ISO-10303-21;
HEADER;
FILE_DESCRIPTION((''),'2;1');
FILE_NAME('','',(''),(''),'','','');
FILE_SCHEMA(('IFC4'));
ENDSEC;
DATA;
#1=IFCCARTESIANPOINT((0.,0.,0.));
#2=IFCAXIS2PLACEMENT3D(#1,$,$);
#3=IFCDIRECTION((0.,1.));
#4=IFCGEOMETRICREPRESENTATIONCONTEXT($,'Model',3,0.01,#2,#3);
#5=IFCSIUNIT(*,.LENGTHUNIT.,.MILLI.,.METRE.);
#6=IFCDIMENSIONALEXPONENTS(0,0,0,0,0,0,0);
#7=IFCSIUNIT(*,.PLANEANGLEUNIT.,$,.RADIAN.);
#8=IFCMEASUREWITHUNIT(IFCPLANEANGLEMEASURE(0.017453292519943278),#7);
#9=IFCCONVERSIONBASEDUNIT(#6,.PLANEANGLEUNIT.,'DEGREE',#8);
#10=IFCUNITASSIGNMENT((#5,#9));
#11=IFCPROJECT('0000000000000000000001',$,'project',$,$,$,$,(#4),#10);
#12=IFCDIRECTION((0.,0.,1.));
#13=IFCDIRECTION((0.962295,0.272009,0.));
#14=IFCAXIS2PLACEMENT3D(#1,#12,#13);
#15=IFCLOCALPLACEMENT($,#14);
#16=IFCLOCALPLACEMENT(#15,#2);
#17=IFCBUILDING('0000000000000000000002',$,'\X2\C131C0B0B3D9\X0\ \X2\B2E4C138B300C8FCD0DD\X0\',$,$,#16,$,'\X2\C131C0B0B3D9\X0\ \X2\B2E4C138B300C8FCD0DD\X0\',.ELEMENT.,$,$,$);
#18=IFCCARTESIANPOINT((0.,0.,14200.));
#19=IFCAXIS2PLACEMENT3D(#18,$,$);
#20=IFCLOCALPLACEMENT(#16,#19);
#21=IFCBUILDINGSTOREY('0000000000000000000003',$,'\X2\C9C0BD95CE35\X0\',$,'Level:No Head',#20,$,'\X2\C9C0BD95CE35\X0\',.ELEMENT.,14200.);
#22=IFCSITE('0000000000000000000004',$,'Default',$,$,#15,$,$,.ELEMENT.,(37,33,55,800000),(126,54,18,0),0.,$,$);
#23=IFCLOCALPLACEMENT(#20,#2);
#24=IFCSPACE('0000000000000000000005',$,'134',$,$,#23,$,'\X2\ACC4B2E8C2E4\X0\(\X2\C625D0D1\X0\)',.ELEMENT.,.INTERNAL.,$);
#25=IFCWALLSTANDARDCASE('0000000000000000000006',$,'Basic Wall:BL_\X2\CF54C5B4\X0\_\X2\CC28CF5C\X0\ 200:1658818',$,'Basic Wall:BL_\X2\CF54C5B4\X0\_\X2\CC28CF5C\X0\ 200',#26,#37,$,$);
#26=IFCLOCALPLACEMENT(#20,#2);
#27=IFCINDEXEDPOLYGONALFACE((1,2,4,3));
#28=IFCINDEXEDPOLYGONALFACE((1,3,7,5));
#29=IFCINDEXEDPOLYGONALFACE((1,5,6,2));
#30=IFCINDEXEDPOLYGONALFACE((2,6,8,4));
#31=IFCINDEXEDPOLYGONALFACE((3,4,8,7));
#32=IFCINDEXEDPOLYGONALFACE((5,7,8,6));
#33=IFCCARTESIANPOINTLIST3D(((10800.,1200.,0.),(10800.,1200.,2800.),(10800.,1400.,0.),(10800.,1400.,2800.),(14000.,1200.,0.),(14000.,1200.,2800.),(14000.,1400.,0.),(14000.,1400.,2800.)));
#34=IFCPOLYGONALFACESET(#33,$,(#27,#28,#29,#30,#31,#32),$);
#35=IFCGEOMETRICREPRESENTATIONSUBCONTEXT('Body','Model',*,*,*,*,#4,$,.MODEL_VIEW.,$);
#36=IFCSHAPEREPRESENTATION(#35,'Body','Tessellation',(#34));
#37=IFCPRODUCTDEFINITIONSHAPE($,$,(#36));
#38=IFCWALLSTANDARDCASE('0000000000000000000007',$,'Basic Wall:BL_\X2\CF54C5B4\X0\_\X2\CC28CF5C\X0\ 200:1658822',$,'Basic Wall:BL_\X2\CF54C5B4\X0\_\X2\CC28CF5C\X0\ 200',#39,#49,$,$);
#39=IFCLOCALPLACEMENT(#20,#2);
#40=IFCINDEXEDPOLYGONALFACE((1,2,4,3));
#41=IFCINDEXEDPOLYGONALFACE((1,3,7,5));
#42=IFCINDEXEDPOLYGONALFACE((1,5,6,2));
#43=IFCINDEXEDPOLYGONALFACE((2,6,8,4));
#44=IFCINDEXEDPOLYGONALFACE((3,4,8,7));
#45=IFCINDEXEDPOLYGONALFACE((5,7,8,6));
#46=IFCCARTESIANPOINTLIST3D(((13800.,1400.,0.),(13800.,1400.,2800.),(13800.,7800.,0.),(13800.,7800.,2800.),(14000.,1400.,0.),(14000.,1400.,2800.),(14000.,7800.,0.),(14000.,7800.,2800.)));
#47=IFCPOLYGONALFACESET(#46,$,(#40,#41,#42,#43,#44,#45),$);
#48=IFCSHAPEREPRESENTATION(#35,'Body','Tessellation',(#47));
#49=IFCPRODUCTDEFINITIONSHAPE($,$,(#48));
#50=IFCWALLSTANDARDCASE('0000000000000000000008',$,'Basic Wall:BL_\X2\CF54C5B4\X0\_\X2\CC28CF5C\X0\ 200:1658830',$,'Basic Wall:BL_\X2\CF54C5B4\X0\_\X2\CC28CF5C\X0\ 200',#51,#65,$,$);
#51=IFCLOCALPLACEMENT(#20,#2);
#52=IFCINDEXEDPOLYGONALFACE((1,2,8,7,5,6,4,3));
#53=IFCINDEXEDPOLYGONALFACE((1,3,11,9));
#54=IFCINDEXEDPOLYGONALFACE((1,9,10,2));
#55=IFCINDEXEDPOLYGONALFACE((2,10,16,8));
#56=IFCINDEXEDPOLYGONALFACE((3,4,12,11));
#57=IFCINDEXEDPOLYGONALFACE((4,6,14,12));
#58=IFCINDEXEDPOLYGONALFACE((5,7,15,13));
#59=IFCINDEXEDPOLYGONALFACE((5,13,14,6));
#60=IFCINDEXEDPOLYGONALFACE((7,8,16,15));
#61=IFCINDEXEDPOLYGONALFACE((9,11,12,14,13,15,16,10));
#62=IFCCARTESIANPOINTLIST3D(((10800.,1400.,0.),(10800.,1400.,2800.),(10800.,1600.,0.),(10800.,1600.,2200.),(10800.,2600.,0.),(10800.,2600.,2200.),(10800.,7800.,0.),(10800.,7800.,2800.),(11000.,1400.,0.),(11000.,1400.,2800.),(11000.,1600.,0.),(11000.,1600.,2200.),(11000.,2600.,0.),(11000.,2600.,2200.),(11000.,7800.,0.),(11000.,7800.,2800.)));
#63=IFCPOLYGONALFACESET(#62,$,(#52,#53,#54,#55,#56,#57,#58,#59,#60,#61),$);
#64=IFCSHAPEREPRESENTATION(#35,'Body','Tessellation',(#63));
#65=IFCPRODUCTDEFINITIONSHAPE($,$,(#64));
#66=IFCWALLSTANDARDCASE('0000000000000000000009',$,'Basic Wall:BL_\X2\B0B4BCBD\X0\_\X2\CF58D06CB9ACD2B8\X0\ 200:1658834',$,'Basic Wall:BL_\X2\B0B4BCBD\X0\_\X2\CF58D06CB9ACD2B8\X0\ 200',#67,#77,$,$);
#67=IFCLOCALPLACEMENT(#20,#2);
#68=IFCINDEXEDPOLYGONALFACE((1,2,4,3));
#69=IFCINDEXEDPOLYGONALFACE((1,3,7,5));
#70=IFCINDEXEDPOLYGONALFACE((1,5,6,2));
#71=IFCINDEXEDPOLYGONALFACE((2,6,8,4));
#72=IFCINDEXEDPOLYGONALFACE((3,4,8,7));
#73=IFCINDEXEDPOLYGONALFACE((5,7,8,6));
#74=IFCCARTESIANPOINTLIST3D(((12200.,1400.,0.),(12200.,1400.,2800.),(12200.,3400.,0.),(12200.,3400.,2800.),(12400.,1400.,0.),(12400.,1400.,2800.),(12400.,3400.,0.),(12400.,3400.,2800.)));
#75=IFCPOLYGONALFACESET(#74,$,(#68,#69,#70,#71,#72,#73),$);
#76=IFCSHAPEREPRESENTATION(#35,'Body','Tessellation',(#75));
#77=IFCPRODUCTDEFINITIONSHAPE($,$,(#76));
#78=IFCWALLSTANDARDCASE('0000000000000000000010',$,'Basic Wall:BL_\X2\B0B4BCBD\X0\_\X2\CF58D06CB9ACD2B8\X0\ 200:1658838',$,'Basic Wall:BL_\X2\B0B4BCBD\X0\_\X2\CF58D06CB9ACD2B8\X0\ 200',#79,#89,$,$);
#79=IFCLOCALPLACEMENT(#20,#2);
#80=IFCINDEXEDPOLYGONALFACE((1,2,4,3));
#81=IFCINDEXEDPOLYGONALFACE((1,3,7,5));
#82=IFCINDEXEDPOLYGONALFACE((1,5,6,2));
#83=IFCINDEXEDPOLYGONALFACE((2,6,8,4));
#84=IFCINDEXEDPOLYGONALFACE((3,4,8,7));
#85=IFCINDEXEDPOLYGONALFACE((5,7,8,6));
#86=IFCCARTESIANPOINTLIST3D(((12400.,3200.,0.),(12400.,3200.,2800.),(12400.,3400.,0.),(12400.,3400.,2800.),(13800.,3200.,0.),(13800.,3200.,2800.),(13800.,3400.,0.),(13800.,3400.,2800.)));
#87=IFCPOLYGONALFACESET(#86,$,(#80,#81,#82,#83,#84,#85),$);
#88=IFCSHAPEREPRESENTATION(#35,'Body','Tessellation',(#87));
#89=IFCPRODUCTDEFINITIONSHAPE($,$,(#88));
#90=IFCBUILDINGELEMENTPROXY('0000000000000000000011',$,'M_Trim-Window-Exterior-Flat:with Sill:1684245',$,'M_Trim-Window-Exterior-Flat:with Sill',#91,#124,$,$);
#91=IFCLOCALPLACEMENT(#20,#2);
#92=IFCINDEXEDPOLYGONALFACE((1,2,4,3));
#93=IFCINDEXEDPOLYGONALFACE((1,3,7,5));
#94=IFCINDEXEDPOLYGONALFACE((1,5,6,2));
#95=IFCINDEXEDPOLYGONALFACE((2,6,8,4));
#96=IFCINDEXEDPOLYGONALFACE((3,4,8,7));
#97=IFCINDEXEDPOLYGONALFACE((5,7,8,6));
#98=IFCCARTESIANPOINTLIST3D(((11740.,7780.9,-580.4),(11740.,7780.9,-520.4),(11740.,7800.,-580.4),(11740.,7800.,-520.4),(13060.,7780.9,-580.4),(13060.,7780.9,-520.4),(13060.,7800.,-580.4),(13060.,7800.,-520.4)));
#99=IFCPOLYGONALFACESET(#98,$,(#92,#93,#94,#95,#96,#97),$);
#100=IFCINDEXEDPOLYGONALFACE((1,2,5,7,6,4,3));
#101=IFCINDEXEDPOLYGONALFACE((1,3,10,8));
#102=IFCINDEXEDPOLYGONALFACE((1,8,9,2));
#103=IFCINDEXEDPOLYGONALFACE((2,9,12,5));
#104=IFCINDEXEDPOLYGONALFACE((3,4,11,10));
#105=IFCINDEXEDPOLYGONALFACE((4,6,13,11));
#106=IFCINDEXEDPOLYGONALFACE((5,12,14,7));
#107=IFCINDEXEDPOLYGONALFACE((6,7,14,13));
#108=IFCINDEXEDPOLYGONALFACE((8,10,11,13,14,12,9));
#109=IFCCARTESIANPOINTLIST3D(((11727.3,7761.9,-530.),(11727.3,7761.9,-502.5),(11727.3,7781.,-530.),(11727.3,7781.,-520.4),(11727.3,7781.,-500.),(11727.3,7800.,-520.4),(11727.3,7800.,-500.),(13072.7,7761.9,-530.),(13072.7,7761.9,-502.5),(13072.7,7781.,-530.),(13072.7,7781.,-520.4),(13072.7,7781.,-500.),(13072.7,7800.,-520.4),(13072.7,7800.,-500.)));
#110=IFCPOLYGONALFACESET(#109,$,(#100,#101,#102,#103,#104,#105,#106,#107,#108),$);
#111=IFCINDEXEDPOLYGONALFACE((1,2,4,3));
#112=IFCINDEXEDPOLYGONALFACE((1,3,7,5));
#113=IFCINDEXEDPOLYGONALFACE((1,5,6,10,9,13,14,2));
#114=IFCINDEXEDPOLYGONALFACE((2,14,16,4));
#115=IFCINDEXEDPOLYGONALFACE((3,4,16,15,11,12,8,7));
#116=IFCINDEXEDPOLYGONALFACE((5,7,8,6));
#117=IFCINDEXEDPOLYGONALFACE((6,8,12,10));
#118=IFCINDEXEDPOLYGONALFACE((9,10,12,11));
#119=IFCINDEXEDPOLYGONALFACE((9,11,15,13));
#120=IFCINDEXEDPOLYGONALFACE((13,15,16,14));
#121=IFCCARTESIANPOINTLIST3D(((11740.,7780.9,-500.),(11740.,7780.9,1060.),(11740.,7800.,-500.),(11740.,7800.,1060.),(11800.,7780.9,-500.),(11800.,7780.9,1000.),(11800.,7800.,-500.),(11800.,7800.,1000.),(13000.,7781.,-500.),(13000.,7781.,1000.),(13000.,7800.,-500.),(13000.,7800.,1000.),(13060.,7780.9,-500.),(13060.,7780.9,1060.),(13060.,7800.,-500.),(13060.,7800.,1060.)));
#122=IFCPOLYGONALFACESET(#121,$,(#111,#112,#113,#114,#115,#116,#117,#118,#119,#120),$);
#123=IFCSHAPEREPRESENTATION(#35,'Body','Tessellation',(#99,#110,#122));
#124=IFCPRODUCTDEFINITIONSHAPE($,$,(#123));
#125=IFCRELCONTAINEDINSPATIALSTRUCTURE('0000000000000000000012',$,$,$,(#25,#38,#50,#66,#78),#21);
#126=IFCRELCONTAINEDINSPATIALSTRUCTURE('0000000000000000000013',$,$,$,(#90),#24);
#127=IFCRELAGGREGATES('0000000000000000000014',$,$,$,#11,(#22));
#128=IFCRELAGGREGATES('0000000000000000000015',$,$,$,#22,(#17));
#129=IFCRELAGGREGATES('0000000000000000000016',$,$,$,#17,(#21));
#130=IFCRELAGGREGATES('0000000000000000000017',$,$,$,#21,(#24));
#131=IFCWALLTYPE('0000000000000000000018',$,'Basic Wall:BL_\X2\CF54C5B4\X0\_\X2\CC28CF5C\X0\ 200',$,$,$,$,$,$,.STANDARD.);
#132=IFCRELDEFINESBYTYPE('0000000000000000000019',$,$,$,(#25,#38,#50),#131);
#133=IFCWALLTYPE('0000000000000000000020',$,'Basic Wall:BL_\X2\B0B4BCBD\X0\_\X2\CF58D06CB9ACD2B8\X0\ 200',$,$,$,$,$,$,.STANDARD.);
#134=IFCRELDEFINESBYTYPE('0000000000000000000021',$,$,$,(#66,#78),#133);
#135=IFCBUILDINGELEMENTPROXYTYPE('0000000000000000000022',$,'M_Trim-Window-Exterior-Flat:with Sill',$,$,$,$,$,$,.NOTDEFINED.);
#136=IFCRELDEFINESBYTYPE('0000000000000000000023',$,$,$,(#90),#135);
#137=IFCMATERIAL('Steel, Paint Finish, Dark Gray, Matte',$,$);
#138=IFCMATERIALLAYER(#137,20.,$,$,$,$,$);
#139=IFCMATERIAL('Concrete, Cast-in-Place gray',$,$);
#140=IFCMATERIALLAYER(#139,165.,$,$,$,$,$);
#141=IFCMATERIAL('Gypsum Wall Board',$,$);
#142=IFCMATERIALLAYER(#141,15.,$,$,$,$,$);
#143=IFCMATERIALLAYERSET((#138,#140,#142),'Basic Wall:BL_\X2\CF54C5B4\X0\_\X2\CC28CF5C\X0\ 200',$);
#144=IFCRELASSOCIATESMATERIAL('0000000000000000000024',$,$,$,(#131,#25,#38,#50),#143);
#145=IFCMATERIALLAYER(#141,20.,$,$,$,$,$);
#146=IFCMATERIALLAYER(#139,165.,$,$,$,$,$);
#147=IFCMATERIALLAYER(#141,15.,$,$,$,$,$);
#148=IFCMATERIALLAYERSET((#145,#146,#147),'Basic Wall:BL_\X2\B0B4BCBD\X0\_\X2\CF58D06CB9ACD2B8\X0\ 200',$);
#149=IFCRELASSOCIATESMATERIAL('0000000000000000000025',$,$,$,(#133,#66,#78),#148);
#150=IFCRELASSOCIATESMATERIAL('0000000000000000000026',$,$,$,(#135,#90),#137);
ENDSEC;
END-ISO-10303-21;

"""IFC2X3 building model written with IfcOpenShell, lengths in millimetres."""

from ifc_helpers import new_model, entity, si_unit, converted_unit, direction, frame, frame_2d, origin, place, context, subcontext, project, spatial, polyline, rectangle, outline, extrude, source, transform, mapped, material, layer, layer_set, layer_usage, type_object, type_shapes, element, save


model = new_model("IFC2X3")

# Units and contexts
model_context = context("Model", 3, precision=0.01, world=origin(), true_north=direction((0.0, 1.0)))
body_context = subcontext(model_context, "Body", "Model", "MODEL_VIEW")
ifc_project = project(units=[si_unit("LENGTHUNIT", "METRE", prefix="MILLI"), converted_unit("PLANEANGLEUNIT", "DEGREE", entity("IfcPlaneAngleMeasure", 0.017453292519943278), si_unit("PLANEANGLEUNIT", "RADIAN"), dimensions=[0, 0, 0, 0, 0, 0, 0])], contexts=[model_context])

# Site, building, storey
site_placement = place(None, frame((0.0, 0.0, 0.0), z_axis=(0.0, 0.0, 1.0), x_axis=(0.962295, 0.272009, 0.0)))
site = spatial("IfcSite", under=ifc_project, at=site_placement, Name="Default", CompositionType="ELEMENT", RefLatitude=(37, 33, 55, 800000), RefLongitude=(126, 54, 18, 0), RefElevation=0.0)
building_placement = place(site_placement, origin())
building = spatial("IfcBuilding", under=site, at=building_placement, Name="성산동 다세대주택", LongName="성산동 다세대주택", CompositionType="ELEMENT")
storey_placement = place(building_placement, frame((0.0, 0.0, 14200.0)))
storey = spatial("IfcBuildingStorey", under=building, at=storey_placement, Name="지붕층", ObjectType="Level:No Head", LongName="지붕층", CompositionType="ELEMENT", Elevation=14200.0)

# Shared definitions
ifc_material_1 = material(Name="Concrete, Cast-in-Place gray")

# Walls
ifc_material_2 = material(Name="Steel, Paint Finish, Dark Gray, Matte")
ifc_layer_1 = layer(ifc_material_2, 20.0)
ifc_layer_2 = layer(ifc_material_1, 165.0)
ifc_material_3 = material(Name="Gypsum Wall Board")
ifc_layer_3 = layer(ifc_material_3, 15.0)
ifc_layer_set_1 = layer_set([ifc_layer_1, ifc_layer_2, ifc_layer_3], Name="Basic Wall:BL_코어_차콜 200")
ifc_layer_usage_1 = layer_usage(ifc_layer_set_1, "AXIS2", "POSITIVE", -100.0)
wall_type_1 = type_object("IfcWallType", Name="Basic Wall:BL_코어_차콜 200", PredefinedType="STANDARD", material=ifc_layer_set_1)
wall_1_placement = place(storey_placement, frame((10800.0, 1300.0, 0.0)))
element("IfcWallStandardCase", 1, at=wall_1_placement, inside=storey, type_object=wall_type_1, material=ifc_layer_usage_1, Name="Basic Wall:BL_코어_차콜 200:1658818", ObjectType="Basic Wall:BL_코어_차콜 200", context=body_context, shape_type="SweptSolid", body=[
    extrude(rectangle(XDim=3200.0, YDim=200.0, at=frame_2d((1600.0, 0.0), x_axis=(-1.0, 0.0))), origin(), (0.0, 0.0, 1.0), 2800.0),
])
ifc_layer_usage_2 = layer_usage(ifc_layer_set_1, "AXIS2", "POSITIVE", -100.0)
wall_2_placement = place(storey_placement, frame((13900.0, 1400.0, 0.0), z_axis=(0.0, 0.0, 1.0), x_axis=(0.0, 1.0, 0.0)))
element("IfcWallStandardCase", 2, at=wall_2_placement, inside=storey, type_object=wall_type_1, material=ifc_layer_usage_2, Name="Basic Wall:BL_코어_차콜 200:1658822", ObjectType="Basic Wall:BL_코어_차콜 200", context=body_context, shape_type="SweptSolid", body=[
    extrude(rectangle(XDim=6400.0, YDim=200.0, at=frame_2d((3200.0, 0.0), x_axis=(-1.0, 0.0))), origin(), (0.0, 0.0, 1.0), 2800.0),
])

# Wall, opening
ifc_layer_usage_3 = layer_usage(ifc_layer_set_1, "AXIS2", "POSITIVE", -100.0)
wall_3_placement = place(storey_placement, frame((10900.0, 7800.0, 0.0), z_axis=(0.0, 0.0, 1.0), x_axis=(0.0, -1.0, 0.0)))
wall_3 = element("IfcWallStandardCase", 3, at=wall_3_placement, inside=storey, type_object=wall_type_1, material=ifc_layer_usage_3, Name="Basic Wall:BL_코어_차콜 200:1658830", ObjectType="Basic Wall:BL_코어_차콜 200", context=body_context, shape_type="SweptSolid", body=[
    extrude(rectangle(XDim=6400.0, YDim=200.0, at=frame_2d((3200.0, 0.0), x_axis=(1.0, 0.0))), origin(), (0.0, 0.0, 1.0), 2800.0),
])
opening_placement = place(wall_3_placement, frame((5200.0, -100.0, 0.0)))
element("IfcOpeningElement", 4, at=opening_placement, cuts=wall_3, ObjectType="Opening", context=body_context, shape_type="SweptSolid", body=[
    extrude(rectangle(XDim=2200.0, YDim=1000.0, at=frame_2d((1100.0, 500.0), x_axis=(1.0, 0.0))), frame((0.0, 0.0, 0.0), z_axis=(0.0, 1.0, 0.0), x_axis=(0.0, 0.0, 1.0)), (0.0, 0.0, 1.0), 200.0),
])

# Walls
ifc_layer_4 = layer(ifc_material_3, 20.0)
ifc_layer_5 = layer(ifc_material_1, 165.0)
ifc_layer_6 = layer(ifc_material_3, 15.0)
ifc_layer_set_2 = layer_set([ifc_layer_4, ifc_layer_5, ifc_layer_6], Name="Basic Wall:BL_내벽_콘크리트 200")
ifc_layer_usage_4 = layer_usage(ifc_layer_set_2, "AXIS2", "NEGATIVE", 100.0)
wall_type_2 = type_object("IfcWallType", Name="Basic Wall:BL_내벽_콘크리트 200", PredefinedType="STANDARD", material=ifc_layer_set_2)
wall_4_placement = place(storey_placement, frame((12300.0, 1400.0, 0.0), z_axis=(0.0, 0.0, 1.0), x_axis=(0.0, 1.0, 0.0)))
element("IfcWallStandardCase", 5, at=wall_4_placement, inside=storey, type_object=wall_type_2, material=ifc_layer_usage_4, Name="Basic Wall:BL_내벽_콘크리트 200:1658834", ObjectType="Basic Wall:BL_내벽_콘크리트 200", context=body_context, shape_type="SweptSolid", body=[
    extrude(rectangle(XDim=2000.0, YDim=200.0, at=frame_2d((1000.0, 0.0), x_axis=(-1.0, 0.0))), origin(), (0.0, 0.0, 1.0), 2800.0),
])
ifc_layer_usage_5 = layer_usage(ifc_layer_set_2, "AXIS2", "NEGATIVE", 100.0)
wall_5_placement = place(storey_placement, frame((12400.0, 3300.0, 0.0)))
element("IfcWallStandardCase", 6, at=wall_5_placement, inside=storey, type_object=wall_type_2, material=ifc_layer_usage_5, Name="Basic Wall:BL_내벽_콘크리트 200:1658838", ObjectType="Basic Wall:BL_내벽_콘크리트 200", context=body_context, shape_type="SweptSolid", body=[
    extrude(rectangle(XDim=1400.0, YDim=200.0, at=frame_2d((700.0, 0.0), x_axis=(-1.0, 0.0))), origin(), (0.0, 0.0, 1.0), 2800.0),
])

# Shared definitions
space_placement = place(storey_placement, origin())
space = spatial("IfcSpace", under=storey, at=space_placement, Name="134", LongName="계단실(옥탑)", CompositionType="ELEMENT", InteriorOrExteriorSpace="INTERNAL")

# Building element proxy
building_element_proxy_type = type_object("IfcBuildingElementProxyType", Name="M_Trim-Window-Exterior-Flat:with Sill", PredefinedType="NOTDEFINED", material=ifc_material_2)
shared_shape = source(origin(), body_context, "Body", "SweptSolid", [
    extrude(rectangle(XDim=1320.0, YDim=60.0, at=frame_2d((0.0, 0.0), x_axis=(1.0, 0.0))), frame((0.0, -1550.4, 0.0), z_axis=(0.0, 0.0, 1.0), x_axis=(-1.0, 0.0, 0.0)), (0.0, 0.0, 1.0), 19.0),
    extrude(outline(polyline([(-19.0, -15.2), (0.0, -15.2), (0.0, -5.7), (19.0, -5.7), (19.0, 14.8), (0.0, 14.8), (-19.0, 12.3), (-19.0, -15.2)])), frame((-672.7, -1514.8, 19.0), z_axis=(1.0, 0.0, 0.0), x_axis=(0.0, 0.0, -1.0)), (0.0, 0.0, 1.0), 1345.4),
    extrude(outline(polyline([(-795.0, -660.0), (765.0, -660.0), (765.0, -600.0), (-735.0, -600.0), (-735.0, 600.0), (765.0, 600.0), (765.0, 660.0), (-795.0, 660.0), (-795.0, -660.0)])), frame((0.0, -735.0, 0.0), z_axis=(0.0, 0.0, 1.0), x_axis=(0.0, -1.0, 0.0)), (0.0, 0.0, 1.0), 19.0),
])
type_shapes(building_element_proxy_type, [shared_shape])
proxy_placement = place(space_placement, frame((12400.0, 7800.0, 1000.0), z_axis=(0.0, -1.0, 0.0), x_axis=(1.0, 0.0, 0.0)))
element("IfcBuildingElementProxy", 7, at=proxy_placement, inside=space, type_object=building_element_proxy_type, material=ifc_material_2, Name="M_Trim-Window-Exterior-Flat:with Sill:1684245", ObjectType="M_Trim-Window-Exterior-Flat:with Sill", context=body_context, shape_type="MappedRepresentation", body=[
    mapped(shared_shape, transform((0.0, 0.0, 0.0), scale=1.0)),
])

save(model, "model.ifc")
